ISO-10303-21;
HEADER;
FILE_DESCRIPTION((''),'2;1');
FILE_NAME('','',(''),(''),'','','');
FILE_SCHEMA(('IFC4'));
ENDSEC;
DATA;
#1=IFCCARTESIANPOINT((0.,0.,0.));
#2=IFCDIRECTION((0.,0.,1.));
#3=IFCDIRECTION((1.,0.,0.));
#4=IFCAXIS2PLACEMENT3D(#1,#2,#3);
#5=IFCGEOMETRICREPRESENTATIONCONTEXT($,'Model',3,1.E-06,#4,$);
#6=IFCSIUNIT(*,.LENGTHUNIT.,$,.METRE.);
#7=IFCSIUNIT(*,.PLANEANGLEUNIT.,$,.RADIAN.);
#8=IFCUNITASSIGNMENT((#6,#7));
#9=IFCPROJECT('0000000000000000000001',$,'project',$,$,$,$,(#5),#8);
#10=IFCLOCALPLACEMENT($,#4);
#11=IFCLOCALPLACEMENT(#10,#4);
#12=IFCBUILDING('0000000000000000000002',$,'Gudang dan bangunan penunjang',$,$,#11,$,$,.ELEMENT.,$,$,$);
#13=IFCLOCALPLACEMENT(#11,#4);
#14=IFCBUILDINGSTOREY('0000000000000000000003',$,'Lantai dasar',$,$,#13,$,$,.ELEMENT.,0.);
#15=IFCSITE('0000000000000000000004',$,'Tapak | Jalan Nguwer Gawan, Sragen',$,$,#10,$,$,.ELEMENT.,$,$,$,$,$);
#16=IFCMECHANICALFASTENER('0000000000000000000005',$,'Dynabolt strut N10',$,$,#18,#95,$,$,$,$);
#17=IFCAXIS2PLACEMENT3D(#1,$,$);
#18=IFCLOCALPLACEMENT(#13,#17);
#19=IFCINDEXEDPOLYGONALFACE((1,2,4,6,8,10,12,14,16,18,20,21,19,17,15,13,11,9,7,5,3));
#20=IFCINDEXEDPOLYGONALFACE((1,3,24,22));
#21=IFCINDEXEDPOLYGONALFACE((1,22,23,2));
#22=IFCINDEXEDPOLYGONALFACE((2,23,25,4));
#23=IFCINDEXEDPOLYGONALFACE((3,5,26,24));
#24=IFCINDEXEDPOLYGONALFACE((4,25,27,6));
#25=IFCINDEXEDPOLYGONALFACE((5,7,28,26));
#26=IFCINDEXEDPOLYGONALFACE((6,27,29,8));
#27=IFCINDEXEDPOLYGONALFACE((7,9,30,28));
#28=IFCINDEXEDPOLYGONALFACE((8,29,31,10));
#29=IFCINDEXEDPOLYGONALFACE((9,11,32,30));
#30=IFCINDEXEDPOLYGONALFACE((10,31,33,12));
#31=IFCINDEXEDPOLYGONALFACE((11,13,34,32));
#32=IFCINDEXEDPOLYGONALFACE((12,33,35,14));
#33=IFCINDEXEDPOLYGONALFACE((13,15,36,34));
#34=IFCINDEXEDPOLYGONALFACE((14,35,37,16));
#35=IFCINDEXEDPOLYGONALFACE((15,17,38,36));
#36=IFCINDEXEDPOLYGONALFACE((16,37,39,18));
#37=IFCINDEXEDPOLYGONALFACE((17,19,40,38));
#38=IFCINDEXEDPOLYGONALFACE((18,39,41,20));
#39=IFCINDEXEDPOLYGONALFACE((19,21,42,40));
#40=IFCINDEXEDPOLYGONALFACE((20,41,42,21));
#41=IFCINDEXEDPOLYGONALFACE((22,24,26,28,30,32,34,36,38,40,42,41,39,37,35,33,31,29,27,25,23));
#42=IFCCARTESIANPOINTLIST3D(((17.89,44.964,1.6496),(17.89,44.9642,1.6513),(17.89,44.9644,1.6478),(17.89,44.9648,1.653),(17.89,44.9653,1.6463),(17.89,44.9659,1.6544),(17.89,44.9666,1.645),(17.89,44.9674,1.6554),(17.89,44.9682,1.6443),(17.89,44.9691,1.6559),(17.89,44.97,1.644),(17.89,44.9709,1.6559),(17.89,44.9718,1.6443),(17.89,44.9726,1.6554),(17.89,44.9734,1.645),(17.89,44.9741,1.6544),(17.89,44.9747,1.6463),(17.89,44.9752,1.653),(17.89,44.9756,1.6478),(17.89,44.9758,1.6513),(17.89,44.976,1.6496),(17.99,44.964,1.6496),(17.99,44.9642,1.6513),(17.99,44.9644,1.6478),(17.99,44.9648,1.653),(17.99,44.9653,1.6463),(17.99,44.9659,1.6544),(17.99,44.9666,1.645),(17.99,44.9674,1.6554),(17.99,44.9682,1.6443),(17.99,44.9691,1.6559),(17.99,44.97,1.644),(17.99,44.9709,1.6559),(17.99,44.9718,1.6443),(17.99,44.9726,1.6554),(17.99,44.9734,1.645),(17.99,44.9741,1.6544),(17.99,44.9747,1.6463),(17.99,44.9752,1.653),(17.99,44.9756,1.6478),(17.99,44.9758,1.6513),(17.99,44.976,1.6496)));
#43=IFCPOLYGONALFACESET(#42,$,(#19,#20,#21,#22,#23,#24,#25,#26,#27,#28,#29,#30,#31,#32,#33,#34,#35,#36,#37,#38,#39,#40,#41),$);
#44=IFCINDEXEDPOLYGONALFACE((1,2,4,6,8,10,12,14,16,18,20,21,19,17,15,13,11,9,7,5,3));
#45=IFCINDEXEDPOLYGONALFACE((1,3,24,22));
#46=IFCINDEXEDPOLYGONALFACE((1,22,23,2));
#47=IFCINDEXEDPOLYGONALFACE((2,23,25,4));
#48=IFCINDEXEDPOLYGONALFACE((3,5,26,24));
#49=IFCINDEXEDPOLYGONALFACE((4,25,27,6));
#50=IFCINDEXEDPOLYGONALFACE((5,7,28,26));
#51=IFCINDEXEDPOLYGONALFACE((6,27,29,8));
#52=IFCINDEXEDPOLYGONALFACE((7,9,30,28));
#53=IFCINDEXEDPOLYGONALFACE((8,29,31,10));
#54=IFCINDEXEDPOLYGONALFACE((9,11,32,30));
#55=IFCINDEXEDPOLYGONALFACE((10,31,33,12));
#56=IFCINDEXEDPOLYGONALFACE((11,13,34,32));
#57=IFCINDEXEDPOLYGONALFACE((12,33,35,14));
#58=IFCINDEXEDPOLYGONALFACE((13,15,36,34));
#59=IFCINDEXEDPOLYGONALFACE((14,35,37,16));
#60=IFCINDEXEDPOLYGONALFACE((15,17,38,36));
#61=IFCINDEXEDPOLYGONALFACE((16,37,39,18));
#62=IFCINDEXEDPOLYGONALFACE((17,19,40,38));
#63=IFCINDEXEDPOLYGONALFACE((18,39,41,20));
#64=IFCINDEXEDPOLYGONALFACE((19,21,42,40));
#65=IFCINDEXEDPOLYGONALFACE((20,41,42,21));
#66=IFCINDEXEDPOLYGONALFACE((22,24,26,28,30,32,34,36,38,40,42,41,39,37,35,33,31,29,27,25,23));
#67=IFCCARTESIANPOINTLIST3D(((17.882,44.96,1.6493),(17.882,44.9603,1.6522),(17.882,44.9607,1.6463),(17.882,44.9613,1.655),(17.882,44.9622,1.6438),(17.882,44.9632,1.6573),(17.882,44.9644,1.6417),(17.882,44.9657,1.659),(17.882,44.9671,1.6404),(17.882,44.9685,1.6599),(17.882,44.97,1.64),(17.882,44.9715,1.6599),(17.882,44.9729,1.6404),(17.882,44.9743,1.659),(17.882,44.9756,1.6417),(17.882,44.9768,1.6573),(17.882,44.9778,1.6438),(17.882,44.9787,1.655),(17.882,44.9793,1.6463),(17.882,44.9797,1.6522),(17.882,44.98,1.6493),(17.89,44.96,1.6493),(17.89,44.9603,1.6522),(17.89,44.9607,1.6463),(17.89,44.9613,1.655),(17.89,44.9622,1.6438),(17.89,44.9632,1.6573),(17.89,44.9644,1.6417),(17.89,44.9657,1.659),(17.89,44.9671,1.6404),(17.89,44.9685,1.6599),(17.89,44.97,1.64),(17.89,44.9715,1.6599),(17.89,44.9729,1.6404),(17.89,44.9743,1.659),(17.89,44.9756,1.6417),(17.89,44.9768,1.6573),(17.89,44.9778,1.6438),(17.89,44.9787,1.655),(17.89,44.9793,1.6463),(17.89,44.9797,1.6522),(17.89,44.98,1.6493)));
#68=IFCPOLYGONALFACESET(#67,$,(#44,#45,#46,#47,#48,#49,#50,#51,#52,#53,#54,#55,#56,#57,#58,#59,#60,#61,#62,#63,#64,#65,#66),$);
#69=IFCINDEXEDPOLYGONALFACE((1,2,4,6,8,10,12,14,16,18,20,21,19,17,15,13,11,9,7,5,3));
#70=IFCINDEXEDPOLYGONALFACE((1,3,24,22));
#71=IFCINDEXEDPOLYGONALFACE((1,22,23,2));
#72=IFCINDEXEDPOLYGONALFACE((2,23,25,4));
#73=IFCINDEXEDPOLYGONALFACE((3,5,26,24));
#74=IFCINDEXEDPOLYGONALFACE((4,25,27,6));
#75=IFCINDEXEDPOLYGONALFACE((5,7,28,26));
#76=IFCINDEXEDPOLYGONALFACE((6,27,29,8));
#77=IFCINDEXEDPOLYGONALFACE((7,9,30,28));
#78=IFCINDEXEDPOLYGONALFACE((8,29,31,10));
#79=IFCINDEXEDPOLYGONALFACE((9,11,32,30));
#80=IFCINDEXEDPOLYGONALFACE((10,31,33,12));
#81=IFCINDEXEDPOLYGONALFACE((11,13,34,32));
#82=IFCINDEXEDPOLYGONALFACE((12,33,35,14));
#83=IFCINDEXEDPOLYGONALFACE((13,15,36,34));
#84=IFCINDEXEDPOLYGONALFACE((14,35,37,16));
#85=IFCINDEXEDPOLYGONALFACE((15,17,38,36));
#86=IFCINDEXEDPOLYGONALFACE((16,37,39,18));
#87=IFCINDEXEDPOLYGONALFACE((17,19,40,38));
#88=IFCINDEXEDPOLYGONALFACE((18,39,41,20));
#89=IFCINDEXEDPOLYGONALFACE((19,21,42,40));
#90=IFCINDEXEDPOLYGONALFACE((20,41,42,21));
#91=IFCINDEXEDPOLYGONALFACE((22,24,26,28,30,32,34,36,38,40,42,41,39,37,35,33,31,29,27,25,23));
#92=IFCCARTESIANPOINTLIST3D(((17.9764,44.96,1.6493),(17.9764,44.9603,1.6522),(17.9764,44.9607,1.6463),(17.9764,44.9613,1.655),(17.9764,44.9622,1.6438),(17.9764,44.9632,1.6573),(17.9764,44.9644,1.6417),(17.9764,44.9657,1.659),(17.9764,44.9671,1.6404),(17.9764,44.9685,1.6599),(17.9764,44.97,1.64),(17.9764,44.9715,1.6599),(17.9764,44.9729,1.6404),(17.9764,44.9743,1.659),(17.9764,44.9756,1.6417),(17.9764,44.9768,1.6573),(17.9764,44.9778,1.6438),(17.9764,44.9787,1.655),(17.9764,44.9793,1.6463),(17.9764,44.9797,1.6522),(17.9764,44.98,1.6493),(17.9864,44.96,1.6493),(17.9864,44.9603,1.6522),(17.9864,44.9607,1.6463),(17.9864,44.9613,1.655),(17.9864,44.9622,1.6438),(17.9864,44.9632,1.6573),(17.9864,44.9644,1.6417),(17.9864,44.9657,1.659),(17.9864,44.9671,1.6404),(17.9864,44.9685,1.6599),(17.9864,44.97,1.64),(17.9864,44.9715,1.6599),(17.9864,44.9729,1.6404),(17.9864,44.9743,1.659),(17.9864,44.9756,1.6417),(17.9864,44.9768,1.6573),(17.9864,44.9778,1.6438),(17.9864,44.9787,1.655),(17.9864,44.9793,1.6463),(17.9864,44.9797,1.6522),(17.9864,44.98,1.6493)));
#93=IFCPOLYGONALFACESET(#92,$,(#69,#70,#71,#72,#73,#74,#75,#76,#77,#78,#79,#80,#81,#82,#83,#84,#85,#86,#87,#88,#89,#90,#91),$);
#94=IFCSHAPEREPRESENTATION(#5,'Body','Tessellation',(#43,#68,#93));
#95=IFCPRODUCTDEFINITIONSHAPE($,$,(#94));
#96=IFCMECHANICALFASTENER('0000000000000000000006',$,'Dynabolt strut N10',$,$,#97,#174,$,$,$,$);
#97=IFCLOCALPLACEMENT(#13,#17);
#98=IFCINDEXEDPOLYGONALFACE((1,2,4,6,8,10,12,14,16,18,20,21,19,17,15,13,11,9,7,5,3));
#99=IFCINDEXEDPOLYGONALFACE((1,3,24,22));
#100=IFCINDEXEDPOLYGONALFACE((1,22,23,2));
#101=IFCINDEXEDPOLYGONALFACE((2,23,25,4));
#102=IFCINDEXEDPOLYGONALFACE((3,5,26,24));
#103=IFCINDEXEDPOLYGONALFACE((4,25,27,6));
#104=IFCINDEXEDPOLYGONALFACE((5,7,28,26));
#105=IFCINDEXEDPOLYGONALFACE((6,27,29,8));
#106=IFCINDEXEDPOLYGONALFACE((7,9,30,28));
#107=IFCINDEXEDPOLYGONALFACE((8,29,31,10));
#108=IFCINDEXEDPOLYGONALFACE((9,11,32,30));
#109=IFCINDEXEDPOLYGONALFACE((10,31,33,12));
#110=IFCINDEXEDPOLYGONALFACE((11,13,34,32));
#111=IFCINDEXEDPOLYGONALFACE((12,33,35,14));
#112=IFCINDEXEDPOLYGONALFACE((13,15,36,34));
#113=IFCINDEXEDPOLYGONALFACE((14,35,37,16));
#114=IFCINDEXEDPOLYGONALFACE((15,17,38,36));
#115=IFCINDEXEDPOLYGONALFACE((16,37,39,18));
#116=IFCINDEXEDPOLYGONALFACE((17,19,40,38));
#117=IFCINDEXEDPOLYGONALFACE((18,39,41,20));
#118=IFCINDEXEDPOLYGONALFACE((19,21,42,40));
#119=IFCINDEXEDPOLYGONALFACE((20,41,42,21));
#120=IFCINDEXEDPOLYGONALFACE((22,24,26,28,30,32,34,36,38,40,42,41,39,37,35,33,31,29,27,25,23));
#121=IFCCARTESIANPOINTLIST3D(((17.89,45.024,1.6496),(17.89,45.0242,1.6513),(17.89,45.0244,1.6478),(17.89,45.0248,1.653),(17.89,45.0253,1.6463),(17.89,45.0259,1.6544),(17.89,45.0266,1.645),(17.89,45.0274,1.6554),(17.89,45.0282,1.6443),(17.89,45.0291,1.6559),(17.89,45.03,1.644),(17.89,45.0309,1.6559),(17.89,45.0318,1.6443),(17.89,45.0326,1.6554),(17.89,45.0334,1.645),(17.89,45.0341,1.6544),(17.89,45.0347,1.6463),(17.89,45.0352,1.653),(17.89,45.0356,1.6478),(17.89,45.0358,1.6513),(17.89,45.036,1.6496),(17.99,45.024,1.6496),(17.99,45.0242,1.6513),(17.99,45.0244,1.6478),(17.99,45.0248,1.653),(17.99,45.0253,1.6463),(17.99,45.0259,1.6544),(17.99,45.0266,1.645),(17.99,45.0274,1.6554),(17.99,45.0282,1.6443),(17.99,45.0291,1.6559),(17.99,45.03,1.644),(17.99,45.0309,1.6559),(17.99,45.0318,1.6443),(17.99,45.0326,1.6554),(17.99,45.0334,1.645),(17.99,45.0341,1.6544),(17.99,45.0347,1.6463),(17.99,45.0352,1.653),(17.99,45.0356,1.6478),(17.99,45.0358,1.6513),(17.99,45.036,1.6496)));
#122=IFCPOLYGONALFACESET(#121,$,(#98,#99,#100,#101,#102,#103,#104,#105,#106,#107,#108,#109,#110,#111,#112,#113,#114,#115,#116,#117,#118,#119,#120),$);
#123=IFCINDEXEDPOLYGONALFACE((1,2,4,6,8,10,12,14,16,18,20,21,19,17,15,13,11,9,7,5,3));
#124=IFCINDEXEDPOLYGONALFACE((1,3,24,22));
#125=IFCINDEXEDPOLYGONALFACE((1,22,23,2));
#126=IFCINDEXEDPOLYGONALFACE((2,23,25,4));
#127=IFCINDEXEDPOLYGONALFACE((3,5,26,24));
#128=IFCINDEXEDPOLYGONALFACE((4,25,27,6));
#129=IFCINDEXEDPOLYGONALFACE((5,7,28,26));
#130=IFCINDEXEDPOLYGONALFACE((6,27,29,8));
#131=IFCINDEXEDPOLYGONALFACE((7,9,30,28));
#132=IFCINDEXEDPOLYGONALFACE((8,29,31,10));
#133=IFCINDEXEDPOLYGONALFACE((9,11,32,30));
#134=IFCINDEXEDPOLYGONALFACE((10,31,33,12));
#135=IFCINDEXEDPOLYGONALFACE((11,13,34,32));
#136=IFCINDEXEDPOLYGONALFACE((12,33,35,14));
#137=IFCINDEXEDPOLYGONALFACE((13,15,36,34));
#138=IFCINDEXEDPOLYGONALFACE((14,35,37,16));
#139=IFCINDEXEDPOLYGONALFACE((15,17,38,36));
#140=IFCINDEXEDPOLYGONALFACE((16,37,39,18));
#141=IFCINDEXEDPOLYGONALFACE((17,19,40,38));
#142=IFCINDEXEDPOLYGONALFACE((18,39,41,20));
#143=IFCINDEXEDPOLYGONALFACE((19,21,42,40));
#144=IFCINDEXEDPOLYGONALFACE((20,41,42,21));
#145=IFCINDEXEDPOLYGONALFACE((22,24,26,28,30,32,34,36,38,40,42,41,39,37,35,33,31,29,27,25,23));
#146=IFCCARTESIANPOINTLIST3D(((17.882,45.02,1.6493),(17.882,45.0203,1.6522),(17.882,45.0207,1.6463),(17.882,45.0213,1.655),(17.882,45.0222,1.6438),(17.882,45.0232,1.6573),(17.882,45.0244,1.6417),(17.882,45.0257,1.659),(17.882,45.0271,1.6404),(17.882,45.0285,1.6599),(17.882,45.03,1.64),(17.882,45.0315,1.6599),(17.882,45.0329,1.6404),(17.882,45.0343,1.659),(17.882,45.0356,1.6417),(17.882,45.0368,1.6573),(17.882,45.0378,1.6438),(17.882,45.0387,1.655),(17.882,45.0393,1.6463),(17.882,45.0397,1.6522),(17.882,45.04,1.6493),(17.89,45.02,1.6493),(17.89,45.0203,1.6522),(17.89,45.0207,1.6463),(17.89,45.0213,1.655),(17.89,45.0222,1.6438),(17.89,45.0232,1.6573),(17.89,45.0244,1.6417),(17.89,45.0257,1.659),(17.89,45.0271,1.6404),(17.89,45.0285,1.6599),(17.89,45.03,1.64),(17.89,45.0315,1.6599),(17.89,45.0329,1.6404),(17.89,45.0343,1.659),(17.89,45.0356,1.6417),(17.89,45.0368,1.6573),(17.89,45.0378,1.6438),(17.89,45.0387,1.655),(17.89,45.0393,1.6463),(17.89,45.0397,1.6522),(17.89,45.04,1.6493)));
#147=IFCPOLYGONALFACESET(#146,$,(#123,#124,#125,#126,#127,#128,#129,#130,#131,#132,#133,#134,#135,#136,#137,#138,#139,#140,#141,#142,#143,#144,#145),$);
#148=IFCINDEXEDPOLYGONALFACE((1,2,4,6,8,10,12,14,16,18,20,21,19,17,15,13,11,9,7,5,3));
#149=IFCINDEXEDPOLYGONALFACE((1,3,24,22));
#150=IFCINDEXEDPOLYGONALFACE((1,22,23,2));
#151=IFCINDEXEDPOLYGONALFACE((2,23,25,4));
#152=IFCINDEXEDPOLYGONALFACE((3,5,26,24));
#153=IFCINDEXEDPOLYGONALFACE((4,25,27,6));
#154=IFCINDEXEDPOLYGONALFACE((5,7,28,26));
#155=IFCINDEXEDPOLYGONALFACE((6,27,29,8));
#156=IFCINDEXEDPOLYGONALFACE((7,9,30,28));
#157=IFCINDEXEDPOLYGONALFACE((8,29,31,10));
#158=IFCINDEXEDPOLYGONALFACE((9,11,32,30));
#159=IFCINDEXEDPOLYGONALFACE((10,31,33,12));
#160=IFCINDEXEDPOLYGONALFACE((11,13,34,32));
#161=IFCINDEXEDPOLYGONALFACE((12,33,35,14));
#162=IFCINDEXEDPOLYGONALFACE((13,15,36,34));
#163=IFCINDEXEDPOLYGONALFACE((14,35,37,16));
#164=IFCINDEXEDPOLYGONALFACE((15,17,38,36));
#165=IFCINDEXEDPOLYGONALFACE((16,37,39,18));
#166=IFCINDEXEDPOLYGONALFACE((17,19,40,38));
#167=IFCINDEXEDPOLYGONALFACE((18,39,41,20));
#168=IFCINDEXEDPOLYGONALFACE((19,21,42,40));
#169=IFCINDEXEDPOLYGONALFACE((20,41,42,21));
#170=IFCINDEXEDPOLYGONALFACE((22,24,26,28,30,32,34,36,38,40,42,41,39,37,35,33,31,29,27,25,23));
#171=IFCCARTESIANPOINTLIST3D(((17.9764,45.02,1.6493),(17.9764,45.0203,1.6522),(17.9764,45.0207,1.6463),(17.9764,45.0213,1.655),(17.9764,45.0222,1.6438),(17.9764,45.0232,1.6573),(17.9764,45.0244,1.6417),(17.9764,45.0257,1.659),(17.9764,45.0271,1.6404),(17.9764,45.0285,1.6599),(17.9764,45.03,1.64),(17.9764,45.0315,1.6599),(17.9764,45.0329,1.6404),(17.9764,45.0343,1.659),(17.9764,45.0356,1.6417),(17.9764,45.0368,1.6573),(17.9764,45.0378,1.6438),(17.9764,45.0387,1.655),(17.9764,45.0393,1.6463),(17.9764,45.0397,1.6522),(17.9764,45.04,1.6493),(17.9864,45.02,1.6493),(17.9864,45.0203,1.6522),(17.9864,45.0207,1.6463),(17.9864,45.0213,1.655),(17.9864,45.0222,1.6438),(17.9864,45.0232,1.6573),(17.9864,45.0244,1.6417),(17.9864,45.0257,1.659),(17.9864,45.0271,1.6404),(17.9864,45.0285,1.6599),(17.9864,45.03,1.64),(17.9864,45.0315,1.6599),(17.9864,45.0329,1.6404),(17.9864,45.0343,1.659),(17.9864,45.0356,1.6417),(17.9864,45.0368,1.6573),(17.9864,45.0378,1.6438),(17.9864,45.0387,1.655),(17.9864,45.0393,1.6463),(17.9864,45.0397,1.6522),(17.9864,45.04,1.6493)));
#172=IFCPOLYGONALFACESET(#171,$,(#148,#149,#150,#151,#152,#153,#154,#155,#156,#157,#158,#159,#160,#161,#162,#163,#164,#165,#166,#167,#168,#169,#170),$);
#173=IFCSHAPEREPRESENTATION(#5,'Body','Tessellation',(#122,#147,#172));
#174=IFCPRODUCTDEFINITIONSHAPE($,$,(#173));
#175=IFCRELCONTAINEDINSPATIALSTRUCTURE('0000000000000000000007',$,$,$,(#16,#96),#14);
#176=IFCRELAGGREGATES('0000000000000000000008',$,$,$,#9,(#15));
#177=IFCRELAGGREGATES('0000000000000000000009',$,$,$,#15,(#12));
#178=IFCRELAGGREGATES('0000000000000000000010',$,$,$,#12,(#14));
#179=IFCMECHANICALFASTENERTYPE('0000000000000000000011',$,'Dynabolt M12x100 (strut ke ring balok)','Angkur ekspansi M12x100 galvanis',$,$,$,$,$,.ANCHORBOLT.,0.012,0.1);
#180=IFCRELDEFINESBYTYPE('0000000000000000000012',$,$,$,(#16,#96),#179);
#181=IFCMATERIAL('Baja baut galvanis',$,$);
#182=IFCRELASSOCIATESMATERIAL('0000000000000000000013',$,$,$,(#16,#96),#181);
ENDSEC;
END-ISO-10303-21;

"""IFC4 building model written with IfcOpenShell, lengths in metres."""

from ifc_helpers import new_model, si_unit, frame, origin_with_axes, place, context, project, spatial, circle, extrude, source, transform, mapped, material, type_object, type_shapes, element, save


model = new_model("IFC4")

# Units and contexts
model_context = context("Model", 3, precision=1e-06, world=origin_with_axes())
ifc_project = project(units=[si_unit("LENGTHUNIT", "METRE"), si_unit("PLANEANGLEUNIT", "RADIAN")], contexts=[model_context])

# Site, building, storey
site_placement = place(None, origin_with_axes())
site = spatial("IfcSite", under=ifc_project, at=site_placement, Name="Tapak | Jalan Nguwer Gawan, Sragen", CompositionType="ELEMENT")
building_placement = place(site_placement, origin_with_axes())
building = spatial("IfcBuilding", under=site, at=building_placement, Name="Gudang dan bangunan penunjang", CompositionType="ELEMENT")
storey_placement = place(building_placement, origin_with_axes())
storey = spatial("IfcBuildingStorey", under=building, at=storey_placement, Name="Lantai dasar", CompositionType="ELEMENT", Elevation=0.0)

# Mechanical fasteners
ifc_material = material(Name="Baja baut galvanis")
mechanical_fastener_type = type_object("IfcMechanicalFastenerType", Name="Dynabolt M12x100 (strut ke ring balok)", Description="Angkur ekspansi M12x100 galvanis", NominalDiameter=0.012, NominalLength=0.1, PredefinedType="ANCHORBOLT")
shared_shape = source(origin_with_axes(), model_context, "Body", "SweptSolid", [
    extrude(circle(Radius=0.006), origin_with_axes(), (0.0, 0.0, 1.0), 0.1),
    extrude(circle(Radius=0.01), frame((0.0, 0.0, -0.008), z_axis=(0.0, 0.0, 1.0), x_axis=(1.0, 0.0, 0.0)), (0.0, 0.0, 1.0), 0.008),
    extrude(circle(Radius=0.01), frame((0.0, 0.0, 0.0864), z_axis=(0.0, 0.0, 1.0), x_axis=(1.0, 0.0, 0.0)), (0.0, 0.0, 1.0), 0.01),
])
type_shapes(mechanical_fastener_type, [shared_shape])
placement = place(None, origin_with_axes())
element("IfcMechanicalFastener", 1, at=placement, inside=storey, type_object=mechanical_fastener_type, material=ifc_material, Name="Dynabolt strut N10", context=model_context, shape_type="MappedRepresentation", body=[
    mapped(shared_shape, transform((17.89, 44.97, 1.65), x_axis=(0.0, 0.0, -1.0), y_axis=(0.0, 1.0, 0.0), z_axis=(1.0, 0.0, 0.0), scale=1.0)),
])
element("IfcMechanicalFastener", 2, at=placement, inside=storey, type_object=mechanical_fastener_type, material=ifc_material, Name="Dynabolt strut N10", context=model_context, shape_type="MappedRepresentation", body=[
    mapped(shared_shape, transform((17.89, 45.03, 1.65), x_axis=(0.0, 0.0, -1.0), y_axis=(0.0, 1.0, 0.0), z_axis=(1.0, 0.0, 0.0), scale=1.0)),
])

save(model, "model.ifc")
